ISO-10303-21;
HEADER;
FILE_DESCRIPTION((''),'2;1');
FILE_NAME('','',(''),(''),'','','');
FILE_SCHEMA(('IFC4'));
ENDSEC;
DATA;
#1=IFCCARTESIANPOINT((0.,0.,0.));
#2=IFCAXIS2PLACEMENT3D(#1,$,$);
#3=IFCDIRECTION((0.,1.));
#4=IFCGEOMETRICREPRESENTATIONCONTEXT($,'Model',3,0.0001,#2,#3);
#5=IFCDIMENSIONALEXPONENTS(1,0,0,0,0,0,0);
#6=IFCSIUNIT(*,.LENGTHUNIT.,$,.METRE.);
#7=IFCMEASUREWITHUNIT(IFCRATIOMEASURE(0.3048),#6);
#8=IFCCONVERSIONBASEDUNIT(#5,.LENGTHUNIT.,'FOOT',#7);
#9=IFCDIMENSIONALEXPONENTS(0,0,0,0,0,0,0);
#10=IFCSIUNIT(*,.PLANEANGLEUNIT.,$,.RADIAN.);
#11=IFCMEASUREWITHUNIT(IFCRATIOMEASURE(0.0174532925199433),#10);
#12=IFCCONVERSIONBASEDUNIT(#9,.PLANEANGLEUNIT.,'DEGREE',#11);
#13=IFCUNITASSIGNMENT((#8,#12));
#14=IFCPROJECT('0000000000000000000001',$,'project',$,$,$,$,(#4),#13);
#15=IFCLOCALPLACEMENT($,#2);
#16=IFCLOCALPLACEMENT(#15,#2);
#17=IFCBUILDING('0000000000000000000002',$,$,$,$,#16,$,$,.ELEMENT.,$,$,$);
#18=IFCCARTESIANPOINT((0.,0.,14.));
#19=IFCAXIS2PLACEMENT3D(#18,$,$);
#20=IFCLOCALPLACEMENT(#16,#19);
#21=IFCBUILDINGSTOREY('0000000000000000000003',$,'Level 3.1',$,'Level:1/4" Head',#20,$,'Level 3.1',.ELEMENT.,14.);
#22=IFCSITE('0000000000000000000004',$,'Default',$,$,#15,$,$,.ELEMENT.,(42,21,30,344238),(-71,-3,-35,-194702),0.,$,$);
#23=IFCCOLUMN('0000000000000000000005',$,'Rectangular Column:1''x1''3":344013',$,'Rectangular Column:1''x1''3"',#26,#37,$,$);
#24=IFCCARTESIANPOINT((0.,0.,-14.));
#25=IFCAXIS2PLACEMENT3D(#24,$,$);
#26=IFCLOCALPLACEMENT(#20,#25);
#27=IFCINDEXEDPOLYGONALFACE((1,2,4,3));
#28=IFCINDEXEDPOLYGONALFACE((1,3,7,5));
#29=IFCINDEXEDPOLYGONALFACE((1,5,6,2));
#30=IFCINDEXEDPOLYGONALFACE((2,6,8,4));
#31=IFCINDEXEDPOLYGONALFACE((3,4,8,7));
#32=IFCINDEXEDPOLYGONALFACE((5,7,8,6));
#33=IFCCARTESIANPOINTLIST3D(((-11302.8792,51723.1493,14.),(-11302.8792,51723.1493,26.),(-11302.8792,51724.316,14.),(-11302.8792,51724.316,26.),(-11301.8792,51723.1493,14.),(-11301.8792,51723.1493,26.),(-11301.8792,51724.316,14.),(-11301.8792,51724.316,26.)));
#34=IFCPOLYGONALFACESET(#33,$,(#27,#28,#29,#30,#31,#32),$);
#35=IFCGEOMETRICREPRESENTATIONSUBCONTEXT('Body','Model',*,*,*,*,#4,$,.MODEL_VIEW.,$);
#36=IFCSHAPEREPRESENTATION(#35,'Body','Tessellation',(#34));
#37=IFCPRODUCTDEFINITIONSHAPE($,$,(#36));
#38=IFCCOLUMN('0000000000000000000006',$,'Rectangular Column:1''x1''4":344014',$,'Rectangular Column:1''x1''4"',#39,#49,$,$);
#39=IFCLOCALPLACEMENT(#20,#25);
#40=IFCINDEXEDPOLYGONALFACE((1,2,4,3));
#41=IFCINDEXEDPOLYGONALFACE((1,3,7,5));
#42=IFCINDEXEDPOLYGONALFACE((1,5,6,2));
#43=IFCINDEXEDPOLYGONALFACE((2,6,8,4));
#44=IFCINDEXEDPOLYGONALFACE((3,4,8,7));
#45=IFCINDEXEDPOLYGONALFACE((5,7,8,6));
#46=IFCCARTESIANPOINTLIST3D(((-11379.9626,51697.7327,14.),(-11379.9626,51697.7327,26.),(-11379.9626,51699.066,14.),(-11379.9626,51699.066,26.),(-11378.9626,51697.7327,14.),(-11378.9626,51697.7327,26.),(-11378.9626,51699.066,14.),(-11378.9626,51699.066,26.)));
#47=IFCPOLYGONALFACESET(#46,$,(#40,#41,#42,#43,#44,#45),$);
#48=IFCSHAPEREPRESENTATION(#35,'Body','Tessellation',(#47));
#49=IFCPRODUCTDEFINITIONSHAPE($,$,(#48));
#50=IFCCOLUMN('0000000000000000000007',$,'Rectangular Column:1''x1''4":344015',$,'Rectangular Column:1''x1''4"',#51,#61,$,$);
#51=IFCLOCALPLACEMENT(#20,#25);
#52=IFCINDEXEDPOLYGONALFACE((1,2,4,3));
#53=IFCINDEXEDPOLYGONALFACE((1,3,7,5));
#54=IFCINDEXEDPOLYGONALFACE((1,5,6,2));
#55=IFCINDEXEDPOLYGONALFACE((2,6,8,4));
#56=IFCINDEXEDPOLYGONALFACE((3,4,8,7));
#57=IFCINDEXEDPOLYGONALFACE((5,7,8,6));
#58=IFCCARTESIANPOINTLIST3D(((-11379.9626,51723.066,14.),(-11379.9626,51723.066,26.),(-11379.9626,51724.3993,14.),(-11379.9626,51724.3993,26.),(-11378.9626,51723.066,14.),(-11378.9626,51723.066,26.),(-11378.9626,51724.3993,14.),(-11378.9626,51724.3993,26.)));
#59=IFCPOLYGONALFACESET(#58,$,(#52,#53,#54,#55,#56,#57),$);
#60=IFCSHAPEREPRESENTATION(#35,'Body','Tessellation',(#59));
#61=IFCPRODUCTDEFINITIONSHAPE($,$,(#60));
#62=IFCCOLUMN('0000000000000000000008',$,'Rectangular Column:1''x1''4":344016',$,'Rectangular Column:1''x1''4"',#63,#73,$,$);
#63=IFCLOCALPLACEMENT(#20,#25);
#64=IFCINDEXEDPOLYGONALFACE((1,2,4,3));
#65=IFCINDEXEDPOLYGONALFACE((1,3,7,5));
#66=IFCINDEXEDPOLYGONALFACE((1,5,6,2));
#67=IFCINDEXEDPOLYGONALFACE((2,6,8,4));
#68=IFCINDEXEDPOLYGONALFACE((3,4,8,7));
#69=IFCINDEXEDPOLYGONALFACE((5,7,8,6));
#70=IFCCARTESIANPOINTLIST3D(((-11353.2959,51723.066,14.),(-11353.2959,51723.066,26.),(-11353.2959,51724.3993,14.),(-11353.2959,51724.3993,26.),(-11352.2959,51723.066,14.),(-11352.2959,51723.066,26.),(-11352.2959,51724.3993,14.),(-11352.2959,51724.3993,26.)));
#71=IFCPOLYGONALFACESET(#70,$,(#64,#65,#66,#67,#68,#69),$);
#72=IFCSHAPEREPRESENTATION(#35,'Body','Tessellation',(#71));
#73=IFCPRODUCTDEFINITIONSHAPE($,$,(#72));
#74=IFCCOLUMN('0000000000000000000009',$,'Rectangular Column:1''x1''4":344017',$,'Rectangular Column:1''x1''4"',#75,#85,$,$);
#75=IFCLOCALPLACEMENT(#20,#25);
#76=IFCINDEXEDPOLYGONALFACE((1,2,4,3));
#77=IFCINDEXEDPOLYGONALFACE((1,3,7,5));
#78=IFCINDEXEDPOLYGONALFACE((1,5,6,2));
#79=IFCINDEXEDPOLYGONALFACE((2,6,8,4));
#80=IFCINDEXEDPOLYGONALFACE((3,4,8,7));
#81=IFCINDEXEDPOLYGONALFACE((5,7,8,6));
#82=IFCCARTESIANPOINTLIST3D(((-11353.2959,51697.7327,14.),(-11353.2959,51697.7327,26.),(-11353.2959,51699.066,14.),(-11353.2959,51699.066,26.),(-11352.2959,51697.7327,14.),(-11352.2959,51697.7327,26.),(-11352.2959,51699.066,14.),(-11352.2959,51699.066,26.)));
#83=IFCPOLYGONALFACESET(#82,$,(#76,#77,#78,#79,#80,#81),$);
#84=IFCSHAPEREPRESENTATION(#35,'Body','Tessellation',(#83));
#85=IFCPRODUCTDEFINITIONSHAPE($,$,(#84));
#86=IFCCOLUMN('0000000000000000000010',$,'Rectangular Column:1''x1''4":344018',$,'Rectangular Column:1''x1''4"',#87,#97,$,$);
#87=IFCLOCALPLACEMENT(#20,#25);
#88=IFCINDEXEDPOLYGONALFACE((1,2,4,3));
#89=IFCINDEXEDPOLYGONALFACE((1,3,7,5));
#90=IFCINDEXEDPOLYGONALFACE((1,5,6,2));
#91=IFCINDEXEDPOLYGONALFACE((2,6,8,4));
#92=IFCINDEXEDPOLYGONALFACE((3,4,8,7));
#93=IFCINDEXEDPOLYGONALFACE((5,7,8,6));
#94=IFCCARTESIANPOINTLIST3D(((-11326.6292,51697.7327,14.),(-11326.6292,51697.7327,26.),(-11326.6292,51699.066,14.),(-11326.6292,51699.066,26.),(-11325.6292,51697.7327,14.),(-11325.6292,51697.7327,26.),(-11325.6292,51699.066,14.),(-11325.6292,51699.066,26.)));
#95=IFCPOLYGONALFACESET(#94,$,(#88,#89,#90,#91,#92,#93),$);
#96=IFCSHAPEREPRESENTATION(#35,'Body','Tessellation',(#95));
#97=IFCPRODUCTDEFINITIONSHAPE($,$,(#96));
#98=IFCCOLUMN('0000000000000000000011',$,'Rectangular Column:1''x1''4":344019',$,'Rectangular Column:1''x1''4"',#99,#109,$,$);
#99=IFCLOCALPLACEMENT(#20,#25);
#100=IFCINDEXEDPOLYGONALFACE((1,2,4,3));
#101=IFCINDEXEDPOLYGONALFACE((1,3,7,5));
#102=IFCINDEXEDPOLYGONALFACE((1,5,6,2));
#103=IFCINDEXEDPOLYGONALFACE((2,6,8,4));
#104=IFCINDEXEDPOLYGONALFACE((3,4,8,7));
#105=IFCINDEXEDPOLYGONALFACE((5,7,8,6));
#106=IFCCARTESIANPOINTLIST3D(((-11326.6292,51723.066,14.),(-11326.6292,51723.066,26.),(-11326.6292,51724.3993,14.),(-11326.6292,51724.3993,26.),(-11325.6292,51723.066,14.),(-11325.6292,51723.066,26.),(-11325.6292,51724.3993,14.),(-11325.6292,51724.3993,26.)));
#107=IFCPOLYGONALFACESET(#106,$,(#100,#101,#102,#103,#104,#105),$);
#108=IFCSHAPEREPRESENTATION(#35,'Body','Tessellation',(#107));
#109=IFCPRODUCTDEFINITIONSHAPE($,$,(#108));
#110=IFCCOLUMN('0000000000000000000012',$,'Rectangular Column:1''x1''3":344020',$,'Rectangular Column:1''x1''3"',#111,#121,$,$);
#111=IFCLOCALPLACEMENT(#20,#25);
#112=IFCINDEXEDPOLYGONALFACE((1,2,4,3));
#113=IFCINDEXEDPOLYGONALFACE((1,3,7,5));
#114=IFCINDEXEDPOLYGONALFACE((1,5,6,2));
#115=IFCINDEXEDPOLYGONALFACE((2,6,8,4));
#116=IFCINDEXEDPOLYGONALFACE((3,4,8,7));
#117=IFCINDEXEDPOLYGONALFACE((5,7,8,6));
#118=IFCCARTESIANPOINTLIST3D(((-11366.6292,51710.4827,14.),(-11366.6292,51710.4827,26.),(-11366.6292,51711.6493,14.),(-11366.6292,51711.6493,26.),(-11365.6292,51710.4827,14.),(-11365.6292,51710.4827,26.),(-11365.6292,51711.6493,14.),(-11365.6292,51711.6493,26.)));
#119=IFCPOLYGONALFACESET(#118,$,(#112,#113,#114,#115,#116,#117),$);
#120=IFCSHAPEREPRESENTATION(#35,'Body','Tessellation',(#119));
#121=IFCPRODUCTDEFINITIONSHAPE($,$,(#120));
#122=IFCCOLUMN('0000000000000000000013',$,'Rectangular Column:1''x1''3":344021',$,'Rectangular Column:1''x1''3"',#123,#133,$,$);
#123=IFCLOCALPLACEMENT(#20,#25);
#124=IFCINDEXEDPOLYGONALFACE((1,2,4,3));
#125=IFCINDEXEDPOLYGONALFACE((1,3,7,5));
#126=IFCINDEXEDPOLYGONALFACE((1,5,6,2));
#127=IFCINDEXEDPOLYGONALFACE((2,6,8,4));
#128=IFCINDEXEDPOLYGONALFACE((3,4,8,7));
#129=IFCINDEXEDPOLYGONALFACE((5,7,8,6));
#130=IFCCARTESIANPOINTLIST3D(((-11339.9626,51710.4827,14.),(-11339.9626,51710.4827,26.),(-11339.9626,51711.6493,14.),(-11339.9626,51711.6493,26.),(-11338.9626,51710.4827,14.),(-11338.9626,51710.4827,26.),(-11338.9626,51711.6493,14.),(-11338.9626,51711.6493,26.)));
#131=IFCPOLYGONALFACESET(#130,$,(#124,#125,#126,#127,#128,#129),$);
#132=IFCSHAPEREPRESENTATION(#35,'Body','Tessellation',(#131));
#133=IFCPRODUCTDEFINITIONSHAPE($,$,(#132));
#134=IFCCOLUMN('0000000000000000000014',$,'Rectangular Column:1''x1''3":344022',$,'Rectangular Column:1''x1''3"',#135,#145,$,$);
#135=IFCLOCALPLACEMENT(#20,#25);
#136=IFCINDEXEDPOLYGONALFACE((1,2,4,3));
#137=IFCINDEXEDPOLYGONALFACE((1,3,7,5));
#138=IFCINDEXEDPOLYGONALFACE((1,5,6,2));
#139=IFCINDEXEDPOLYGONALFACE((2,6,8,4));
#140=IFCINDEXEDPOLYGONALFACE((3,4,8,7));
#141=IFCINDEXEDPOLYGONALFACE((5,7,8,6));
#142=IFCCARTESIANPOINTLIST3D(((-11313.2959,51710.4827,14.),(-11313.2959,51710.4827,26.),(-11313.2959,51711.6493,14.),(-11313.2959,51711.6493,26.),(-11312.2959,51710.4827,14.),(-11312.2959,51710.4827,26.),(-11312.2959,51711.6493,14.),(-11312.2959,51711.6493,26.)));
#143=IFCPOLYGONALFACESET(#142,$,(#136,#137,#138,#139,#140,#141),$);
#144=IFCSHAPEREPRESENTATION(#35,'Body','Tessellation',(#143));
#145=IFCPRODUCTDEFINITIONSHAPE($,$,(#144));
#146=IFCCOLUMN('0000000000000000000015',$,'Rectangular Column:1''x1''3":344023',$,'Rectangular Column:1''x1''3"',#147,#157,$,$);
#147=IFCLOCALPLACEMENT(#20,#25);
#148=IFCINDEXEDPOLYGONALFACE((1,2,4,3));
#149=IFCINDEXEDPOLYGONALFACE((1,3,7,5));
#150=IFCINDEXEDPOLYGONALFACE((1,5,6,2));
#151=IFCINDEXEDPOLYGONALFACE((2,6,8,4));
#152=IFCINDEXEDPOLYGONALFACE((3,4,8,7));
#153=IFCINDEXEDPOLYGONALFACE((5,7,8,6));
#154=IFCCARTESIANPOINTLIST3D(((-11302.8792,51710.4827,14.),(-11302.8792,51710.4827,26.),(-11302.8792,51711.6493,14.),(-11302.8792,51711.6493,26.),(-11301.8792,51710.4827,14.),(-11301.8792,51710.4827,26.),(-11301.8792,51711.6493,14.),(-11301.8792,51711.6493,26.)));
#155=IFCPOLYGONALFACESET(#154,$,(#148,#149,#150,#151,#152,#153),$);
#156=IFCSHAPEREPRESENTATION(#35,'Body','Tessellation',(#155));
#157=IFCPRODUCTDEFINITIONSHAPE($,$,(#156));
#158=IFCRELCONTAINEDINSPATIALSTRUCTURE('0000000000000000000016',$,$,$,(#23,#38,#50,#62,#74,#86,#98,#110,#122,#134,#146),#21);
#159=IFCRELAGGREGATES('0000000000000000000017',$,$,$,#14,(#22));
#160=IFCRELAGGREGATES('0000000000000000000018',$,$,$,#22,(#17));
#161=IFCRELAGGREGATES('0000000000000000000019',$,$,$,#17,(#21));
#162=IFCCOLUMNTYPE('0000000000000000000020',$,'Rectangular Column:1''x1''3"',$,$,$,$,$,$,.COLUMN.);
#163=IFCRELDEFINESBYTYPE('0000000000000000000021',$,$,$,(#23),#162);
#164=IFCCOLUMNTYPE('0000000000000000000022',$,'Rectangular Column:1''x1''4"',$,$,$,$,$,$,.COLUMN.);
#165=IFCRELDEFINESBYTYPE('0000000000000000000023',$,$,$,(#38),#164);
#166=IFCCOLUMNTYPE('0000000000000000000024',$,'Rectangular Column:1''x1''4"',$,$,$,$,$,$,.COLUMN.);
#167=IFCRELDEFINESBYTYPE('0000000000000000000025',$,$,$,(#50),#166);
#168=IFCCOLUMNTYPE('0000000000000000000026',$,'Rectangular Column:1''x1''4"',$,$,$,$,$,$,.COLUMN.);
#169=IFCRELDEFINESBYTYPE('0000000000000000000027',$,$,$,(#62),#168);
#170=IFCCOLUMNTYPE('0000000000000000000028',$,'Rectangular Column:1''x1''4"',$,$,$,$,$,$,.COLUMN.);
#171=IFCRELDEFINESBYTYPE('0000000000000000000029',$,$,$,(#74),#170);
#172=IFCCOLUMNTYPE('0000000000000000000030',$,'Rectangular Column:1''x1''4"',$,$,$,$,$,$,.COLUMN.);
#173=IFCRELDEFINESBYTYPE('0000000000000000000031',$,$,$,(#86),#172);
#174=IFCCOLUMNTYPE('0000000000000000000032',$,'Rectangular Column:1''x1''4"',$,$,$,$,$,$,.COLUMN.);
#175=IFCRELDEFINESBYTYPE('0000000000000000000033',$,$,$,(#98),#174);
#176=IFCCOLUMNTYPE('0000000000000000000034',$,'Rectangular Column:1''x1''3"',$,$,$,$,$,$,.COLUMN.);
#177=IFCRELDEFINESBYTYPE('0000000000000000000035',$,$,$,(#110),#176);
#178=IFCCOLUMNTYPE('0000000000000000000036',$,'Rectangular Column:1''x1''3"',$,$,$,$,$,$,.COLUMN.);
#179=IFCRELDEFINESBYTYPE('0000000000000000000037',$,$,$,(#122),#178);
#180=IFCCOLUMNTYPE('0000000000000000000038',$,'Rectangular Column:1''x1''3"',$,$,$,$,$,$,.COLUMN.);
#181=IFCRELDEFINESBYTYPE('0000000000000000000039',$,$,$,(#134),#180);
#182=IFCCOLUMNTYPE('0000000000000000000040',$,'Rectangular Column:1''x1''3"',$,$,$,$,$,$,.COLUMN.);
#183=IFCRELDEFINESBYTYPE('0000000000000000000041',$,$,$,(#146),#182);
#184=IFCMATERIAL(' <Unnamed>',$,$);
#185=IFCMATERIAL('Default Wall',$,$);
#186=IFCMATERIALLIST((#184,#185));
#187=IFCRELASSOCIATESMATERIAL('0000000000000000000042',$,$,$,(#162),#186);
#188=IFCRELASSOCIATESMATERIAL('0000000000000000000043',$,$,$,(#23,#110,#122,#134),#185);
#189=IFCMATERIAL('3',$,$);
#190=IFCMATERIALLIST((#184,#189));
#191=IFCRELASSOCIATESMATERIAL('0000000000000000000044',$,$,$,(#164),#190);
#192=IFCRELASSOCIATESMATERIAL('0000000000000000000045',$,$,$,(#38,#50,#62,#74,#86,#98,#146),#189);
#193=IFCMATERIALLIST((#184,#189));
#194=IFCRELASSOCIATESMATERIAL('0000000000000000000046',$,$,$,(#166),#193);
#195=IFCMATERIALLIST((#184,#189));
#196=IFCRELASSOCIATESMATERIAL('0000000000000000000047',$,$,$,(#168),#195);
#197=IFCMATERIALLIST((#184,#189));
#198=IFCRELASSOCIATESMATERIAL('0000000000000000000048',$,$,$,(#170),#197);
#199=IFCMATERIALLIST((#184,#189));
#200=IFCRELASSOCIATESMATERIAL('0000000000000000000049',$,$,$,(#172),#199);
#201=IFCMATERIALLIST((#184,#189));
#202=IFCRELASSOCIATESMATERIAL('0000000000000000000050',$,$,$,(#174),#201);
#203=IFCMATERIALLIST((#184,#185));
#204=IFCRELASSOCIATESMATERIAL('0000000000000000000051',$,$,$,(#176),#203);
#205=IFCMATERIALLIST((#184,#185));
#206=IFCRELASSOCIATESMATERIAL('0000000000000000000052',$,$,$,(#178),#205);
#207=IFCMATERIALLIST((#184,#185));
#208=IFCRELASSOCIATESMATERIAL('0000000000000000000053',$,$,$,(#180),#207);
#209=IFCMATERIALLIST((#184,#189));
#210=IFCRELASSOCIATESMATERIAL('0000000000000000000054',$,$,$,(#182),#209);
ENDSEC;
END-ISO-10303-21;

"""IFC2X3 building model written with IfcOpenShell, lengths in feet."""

from ifc_helpers import new_model, entity, si_unit, converted_unit, direction, frame, frame_2d, origin, place, context, subcontext, project, spatial, rectangle, extrude, source, transform, mapped, material, material_list, type_object, type_shapes, element, save


model = new_model("IFC2X3")

# Units and contexts
model_context = context("Model", 3, precision=0.0001, world=origin(), true_north=direction((0.0, 1.0)))
body_context = subcontext(model_context, "Body", "Model", "MODEL_VIEW")
ifc_project = project(units=[converted_unit("LENGTHUNIT", "FOOT", entity("IfcRatioMeasure", 0.3048), si_unit("LENGTHUNIT", "METRE"), dimensions=[1, 0, 0, 0, 0, 0, 0]), converted_unit("PLANEANGLEUNIT", "DEGREE", entity("IfcRatioMeasure", 0.0174532925199433), si_unit("PLANEANGLEUNIT", "RADIAN"), dimensions=[0, 0, 0, 0, 0, 0, 0])], contexts=[model_context])

# Site, building, storey
site_placement = place(None, origin())
site = spatial("IfcSite", under=ifc_project, at=site_placement, Name="Default", CompositionType="ELEMENT", RefLatitude=(42, 21, 30, 344238), RefLongitude=(-71, -3, -35, -194702), RefElevation=0.0)
building_placement = place(site_placement, origin())
building = spatial("IfcBuilding", under=site, at=building_placement, CompositionType="ELEMENT")
storey_placement = place(building_placement, frame((0.0, 0.0, 14.0)))
storey = spatial("IfcBuildingStorey", under=building, at=storey_placement, Name="Level 3.1", ObjectType="Level:1/4\" Head", LongName="Level 3.1", CompositionType="ELEMENT", Elevation=14.0)

# Columns
ifc_material_1 = material(Name="Default Wall")
ifc_material_2 = material(Name=" <Unnamed>")
ifc_material_list_1 = material_list([ifc_material_2, ifc_material_1])
column_type_1 = type_object("IfcColumnType", Name="Rectangular Column:1'x1'3\"", PredefinedType="COLUMN", material=ifc_material_list_1)
shared_shape_1 = source(origin(), body_context, "Body", "SweptSolid", [
    extrude(rectangle(XDim=1.1667, YDim=1.0, at=frame_2d((0.0, 0.0), x_axis=(1.0, 0.0))), frame((-11302.3792, 51723.7327, 14.0), z_axis=(0.0, 0.0, 1.0), x_axis=(0.0, -1.0, 0.0)), (0.0, 0.0, 1.0), 12.0),
])
type_shapes(column_type_1, [shared_shape_1])
column_1_placement = place(storey_placement, frame((0.0, 0.0, -14.0)))
element("IfcColumn", 1, at=column_1_placement, inside=storey, type_object=column_type_1, material=ifc_material_1, Name="Rectangular Column:1'x1'3\":344013", ObjectType="Rectangular Column:1'x1'3\"", context=body_context, shape_type="MappedRepresentation", body=[
    mapped(shared_shape_1, transform((0.0, 0.0, 0.0), scale=1.0)),
])
ifc_material_3 = material(Name="3")
ifc_material_list_2 = material_list([ifc_material_2, ifc_material_3])
column_type_2 = type_object("IfcColumnType", Name="Rectangular Column:1'x1'4\"", PredefinedType="COLUMN", material=ifc_material_list_2)
shared_shape_2 = source(origin(), body_context, "Body", "SweptSolid", [
    extrude(rectangle(XDim=1.3333, YDim=1.0, at=frame_2d((0.0, 0.0), x_axis=(1.0, 0.0))), frame((-11379.4626, 51698.3993, 14.0), z_axis=(0.0, 0.0, 1.0), x_axis=(0.0, -1.0, 0.0)), (0.0, 0.0, 1.0), 12.0),
])
type_shapes(column_type_2, [shared_shape_2])
column_2_placement = place(storey_placement, frame((0.0, 0.0, -14.0)))
element("IfcColumn", 2, at=column_2_placement, inside=storey, type_object=column_type_2, material=ifc_material_3, Name="Rectangular Column:1'x1'4\":344014", ObjectType="Rectangular Column:1'x1'4\"", context=body_context, shape_type="MappedRepresentation", body=[
    mapped(shared_shape_2, transform((0.0, 0.0, 0.0), scale=1.0)),
])
ifc_material_list_3 = material_list([ifc_material_2, ifc_material_3])
column_type_3 = type_object("IfcColumnType", Name="Rectangular Column:1'x1'4\"", PredefinedType="COLUMN", material=ifc_material_list_3)
shared_shape_3 = source(origin(), body_context, "Body", "SweptSolid", [
    extrude(rectangle(XDim=1.3333, YDim=1.0, at=frame_2d((0.0, 0.0), x_axis=(1.0, 0.0))), frame((-11379.4626, 51723.7327, 14.0), z_axis=(0.0, 0.0, 1.0), x_axis=(0.0, -1.0, 0.0)), (0.0, 0.0, 1.0), 12.0),
])
type_shapes(column_type_3, [shared_shape_3])
column_3_placement = place(storey_placement, frame((0.0, 0.0, -14.0)))
element("IfcColumn", 3, at=column_3_placement, inside=storey, type_object=column_type_3, material=ifc_material_3, Name="Rectangular Column:1'x1'4\":344015", ObjectType="Rectangular Column:1'x1'4\"", context=body_context, shape_type="MappedRepresentation", body=[
    mapped(shared_shape_3, transform((0.0, 0.0, 0.0), scale=1.0)),
])
ifc_material_list_4 = material_list([ifc_material_2, ifc_material_3])
column_type_4 = type_object("IfcColumnType", Name="Rectangular Column:1'x1'4\"", PredefinedType="COLUMN", material=ifc_material_list_4)
shared_shape_4 = source(origin(), body_context, "Body", "SweptSolid", [
    extrude(rectangle(XDim=1.3333, YDim=1.0, at=frame_2d((0.0, 0.0), x_axis=(1.0, 0.0))), frame((-11352.7959, 51723.7327, 14.0), z_axis=(0.0, 0.0, 1.0), x_axis=(0.0, -1.0, 0.0)), (0.0, 0.0, 1.0), 12.0),
])
type_shapes(column_type_4, [shared_shape_4])
column_4_placement = place(storey_placement, frame((0.0, 0.0, -14.0)))
element("IfcColumn", 4, at=column_4_placement, inside=storey, type_object=column_type_4, material=ifc_material_3, Name="Rectangular Column:1'x1'4\":344016", ObjectType="Rectangular Column:1'x1'4\"", context=body_context, shape_type="MappedRepresentation", body=[
    mapped(shared_shape_4, transform((0.0, 0.0, 0.0), scale=1.0)),
])
ifc_material_list_5 = material_list([ifc_material_2, ifc_material_3])
column_type_5 = type_object("IfcColumnType", Name="Rectangular Column:1'x1'4\"", PredefinedType="COLUMN", material=ifc_material_list_5)
shared_shape_5 = source(origin(), body_context, "Body", "SweptSolid", [
    extrude(rectangle(XDim=1.3333, YDim=1.0, at=frame_2d((0.0, 0.0), x_axis=(1.0, 0.0))), frame((-11352.7959, 51698.3993, 14.0), z_axis=(0.0, 0.0, 1.0), x_axis=(0.0, -1.0, 0.0)), (0.0, 0.0, 1.0), 12.0),
])
type_shapes(column_type_5, [shared_shape_5])
column_5_placement = place(storey_placement, frame((0.0, 0.0, -14.0)))
element("IfcColumn", 5, at=column_5_placement, inside=storey, type_object=column_type_5, material=ifc_material_3, Name="Rectangular Column:1'x1'4\":344017", ObjectType="Rectangular Column:1'x1'4\"", context=body_context, shape_type="MappedRepresentation", body=[
    mapped(shared_shape_5, transform((0.0, 0.0, 0.0), scale=1.0)),
])
ifc_material_list_6 = material_list([ifc_material_2, ifc_material_3])
column_type_6 = type_object("IfcColumnType", Name="Rectangular Column:1'x1'4\"", PredefinedType="COLUMN", material=ifc_material_list_6)
shared_shape_6 = source(origin(), body_context, "Body", "SweptSolid", [
    extrude(rectangle(XDim=1.3333, YDim=1.0, at=frame_2d((0.0, 0.0), x_axis=(1.0, 0.0))), frame((-11326.1292, 51698.3993, 14.0), z_axis=(0.0, 0.0, 1.0), x_axis=(0.0, -1.0, 0.0)), (0.0, 0.0, 1.0), 12.0),
])
type_shapes(column_type_6, [shared_shape_6])
column_6_placement = place(storey_placement, frame((0.0, 0.0, -14.0)))
element("IfcColumn", 6, at=column_6_placement, inside=storey, type_object=column_type_6, material=ifc_material_3, Name="Rectangular Column:1'x1'4\":344018", ObjectType="Rectangular Column:1'x1'4\"", context=body_context, shape_type="MappedRepresentation", body=[
    mapped(shared_shape_6, transform((0.0, 0.0, 0.0), scale=1.0)),
])
ifc_material_list_7 = material_list([ifc_material_2, ifc_material_3])
column_type_7 = type_object("IfcColumnType", Name="Rectangular Column:1'x1'4\"", PredefinedType="COLUMN", material=ifc_material_list_7)
shared_shape_7 = source(origin(), body_context, "Body", "SweptSolid", [
    extrude(rectangle(XDim=1.3333, YDim=1.0, at=frame_2d((0.0, 0.0), x_axis=(1.0, 0.0))), frame((-11326.1292, 51723.7327, 14.0), z_axis=(0.0, 0.0, 1.0), x_axis=(0.0, -1.0, 0.0)), (0.0, 0.0, 1.0), 12.0),
])
type_shapes(column_type_7, [shared_shape_7])
column_7_placement = place(storey_placement, frame((0.0, 0.0, -14.0)))
element("IfcColumn", 7, at=column_7_placement, inside=storey, type_object=column_type_7, material=ifc_material_3, Name="Rectangular Column:1'x1'4\":344019", ObjectType="Rectangular Column:1'x1'4\"", context=body_context, shape_type="MappedRepresentation", body=[
    mapped(shared_shape_7, transform((0.0, 0.0, 0.0), scale=1.0)),
])
ifc_material_list_8 = material_list([ifc_material_2, ifc_material_1])
column_type_8 = type_object("IfcColumnType", Name="Rectangular Column:1'x1'3\"", PredefinedType="COLUMN", material=ifc_material_list_8)
shared_shape_8 = source(origin(), body_context, "Body", "SweptSolid", [
    extrude(rectangle(XDim=1.1667, YDim=1.0, at=frame_2d((0.0, 0.0), x_axis=(1.0, 0.0))), frame((-11366.1292, 51711.066, 14.0), z_axis=(0.0, 0.0, 1.0), x_axis=(0.0, -1.0, 0.0)), (0.0, 0.0, 1.0), 12.0),
])
type_shapes(column_type_8, [shared_shape_8])
column_8_placement = place(storey_placement, frame((0.0, 0.0, -14.0)))
element("IfcColumn", 8, at=column_8_placement, inside=storey, type_object=column_type_8, material=ifc_material_1, Name="Rectangular Column:1'x1'3\":344020", ObjectType="Rectangular Column:1'x1'3\"", context=body_context, shape_type="MappedRepresentation", body=[
    mapped(shared_shape_8, transform((0.0, 0.0, 0.0), scale=1.0)),
])
ifc_material_list_9 = material_list([ifc_material_2, ifc_material_1])
column_type_9 = type_object("IfcColumnType", Name="Rectangular Column:1'x1'3\"", PredefinedType="COLUMN", material=ifc_material_list_9)
shared_shape_9 = source(origin(), body_context, "Body", "SweptSolid", [
    extrude(rectangle(XDim=1.1667, YDim=1.0, at=frame_2d((0.0, 0.0), x_axis=(1.0, 0.0))), frame((-11339.4626, 51711.066, 14.0), z_axis=(0.0, 0.0, 1.0), x_axis=(0.0, -1.0, 0.0)), (0.0, 0.0, 1.0), 12.0),
])
type_shapes(column_type_9, [shared_shape_9])
column_9_placement = place(storey_placement, frame((0.0, 0.0, -14.0)))
element("IfcColumn", 9, at=column_9_placement, inside=storey, type_object=column_type_9, material=ifc_material_1, Name="Rectangular Column:1'x1'3\":344021", ObjectType="Rectangular Column:1'x1'3\"", context=body_context, shape_type="MappedRepresentation", body=[
    mapped(shared_shape_9, transform((0.0, 0.0, 0.0), scale=1.0)),
])
ifc_material_list_10 = material_list([ifc_material_2, ifc_material_1])
column_type_10 = type_object("IfcColumnType", Name="Rectangular Column:1'x1'3\"", PredefinedType="COLUMN", material=ifc_material_list_10)
shared_shape_10 = source(origin(), body_context, "Body", "SweptSolid", [
    extrude(rectangle(XDim=1.1667, YDim=1.0, at=frame_2d((0.0, 0.0), x_axis=(1.0, 0.0))), frame((-11312.7959, 51711.066, 14.0), z_axis=(0.0, 0.0, 1.0), x_axis=(0.0, -1.0, 0.0)), (0.0, 0.0, 1.0), 12.0),
])
type_shapes(column_type_10, [shared_shape_10])
column_10_placement = place(storey_placement, frame((0.0, 0.0, -14.0)))
element("IfcColumn", 10, at=column_10_placement, inside=storey, type_object=column_type_10, material=ifc_material_1, Name="Rectangular Column:1'x1'3\":344022", ObjectType="Rectangular Column:1'x1'3\"", context=body_context, shape_type="MappedRepresentation", body=[
    mapped(shared_shape_10, transform((0.0, 0.0, 0.0), scale=1.0)),
])
ifc_material_list_11 = material_list([ifc_material_2, ifc_material_3])
column_type_11 = type_object("IfcColumnType", Name="Rectangular Column:1'x1'3\"", PredefinedType="COLUMN", material=ifc_material_list_11)
shared_shape_11 = source(origin(), body_context, "Body", "SweptSolid", [
    extrude(rectangle(XDim=1.1667, YDim=1.0, at=frame_2d((0.0, 0.0), x_axis=(1.0, 0.0))), frame((-11302.3792, 51711.066, 14.0), z_axis=(0.0, 0.0, 1.0), x_axis=(0.0, -1.0, 0.0)), (0.0, 0.0, 1.0), 12.0),
])
type_shapes(column_type_11, [shared_shape_11])
column_11_placement = place(storey_placement, frame((0.0, 0.0, -14.0)))
element("IfcColumn", 11, at=column_11_placement, inside=storey, type_object=column_type_11, material=ifc_material_3, Name="Rectangular Column:1'x1'3\":344023", ObjectType="Rectangular Column:1'x1'3\"", context=body_context, shape_type="MappedRepresentation", body=[
    mapped(shared_shape_11, transform((0.0, 0.0, 0.0), scale=1.0)),
])

save(model, "model.ifc")
